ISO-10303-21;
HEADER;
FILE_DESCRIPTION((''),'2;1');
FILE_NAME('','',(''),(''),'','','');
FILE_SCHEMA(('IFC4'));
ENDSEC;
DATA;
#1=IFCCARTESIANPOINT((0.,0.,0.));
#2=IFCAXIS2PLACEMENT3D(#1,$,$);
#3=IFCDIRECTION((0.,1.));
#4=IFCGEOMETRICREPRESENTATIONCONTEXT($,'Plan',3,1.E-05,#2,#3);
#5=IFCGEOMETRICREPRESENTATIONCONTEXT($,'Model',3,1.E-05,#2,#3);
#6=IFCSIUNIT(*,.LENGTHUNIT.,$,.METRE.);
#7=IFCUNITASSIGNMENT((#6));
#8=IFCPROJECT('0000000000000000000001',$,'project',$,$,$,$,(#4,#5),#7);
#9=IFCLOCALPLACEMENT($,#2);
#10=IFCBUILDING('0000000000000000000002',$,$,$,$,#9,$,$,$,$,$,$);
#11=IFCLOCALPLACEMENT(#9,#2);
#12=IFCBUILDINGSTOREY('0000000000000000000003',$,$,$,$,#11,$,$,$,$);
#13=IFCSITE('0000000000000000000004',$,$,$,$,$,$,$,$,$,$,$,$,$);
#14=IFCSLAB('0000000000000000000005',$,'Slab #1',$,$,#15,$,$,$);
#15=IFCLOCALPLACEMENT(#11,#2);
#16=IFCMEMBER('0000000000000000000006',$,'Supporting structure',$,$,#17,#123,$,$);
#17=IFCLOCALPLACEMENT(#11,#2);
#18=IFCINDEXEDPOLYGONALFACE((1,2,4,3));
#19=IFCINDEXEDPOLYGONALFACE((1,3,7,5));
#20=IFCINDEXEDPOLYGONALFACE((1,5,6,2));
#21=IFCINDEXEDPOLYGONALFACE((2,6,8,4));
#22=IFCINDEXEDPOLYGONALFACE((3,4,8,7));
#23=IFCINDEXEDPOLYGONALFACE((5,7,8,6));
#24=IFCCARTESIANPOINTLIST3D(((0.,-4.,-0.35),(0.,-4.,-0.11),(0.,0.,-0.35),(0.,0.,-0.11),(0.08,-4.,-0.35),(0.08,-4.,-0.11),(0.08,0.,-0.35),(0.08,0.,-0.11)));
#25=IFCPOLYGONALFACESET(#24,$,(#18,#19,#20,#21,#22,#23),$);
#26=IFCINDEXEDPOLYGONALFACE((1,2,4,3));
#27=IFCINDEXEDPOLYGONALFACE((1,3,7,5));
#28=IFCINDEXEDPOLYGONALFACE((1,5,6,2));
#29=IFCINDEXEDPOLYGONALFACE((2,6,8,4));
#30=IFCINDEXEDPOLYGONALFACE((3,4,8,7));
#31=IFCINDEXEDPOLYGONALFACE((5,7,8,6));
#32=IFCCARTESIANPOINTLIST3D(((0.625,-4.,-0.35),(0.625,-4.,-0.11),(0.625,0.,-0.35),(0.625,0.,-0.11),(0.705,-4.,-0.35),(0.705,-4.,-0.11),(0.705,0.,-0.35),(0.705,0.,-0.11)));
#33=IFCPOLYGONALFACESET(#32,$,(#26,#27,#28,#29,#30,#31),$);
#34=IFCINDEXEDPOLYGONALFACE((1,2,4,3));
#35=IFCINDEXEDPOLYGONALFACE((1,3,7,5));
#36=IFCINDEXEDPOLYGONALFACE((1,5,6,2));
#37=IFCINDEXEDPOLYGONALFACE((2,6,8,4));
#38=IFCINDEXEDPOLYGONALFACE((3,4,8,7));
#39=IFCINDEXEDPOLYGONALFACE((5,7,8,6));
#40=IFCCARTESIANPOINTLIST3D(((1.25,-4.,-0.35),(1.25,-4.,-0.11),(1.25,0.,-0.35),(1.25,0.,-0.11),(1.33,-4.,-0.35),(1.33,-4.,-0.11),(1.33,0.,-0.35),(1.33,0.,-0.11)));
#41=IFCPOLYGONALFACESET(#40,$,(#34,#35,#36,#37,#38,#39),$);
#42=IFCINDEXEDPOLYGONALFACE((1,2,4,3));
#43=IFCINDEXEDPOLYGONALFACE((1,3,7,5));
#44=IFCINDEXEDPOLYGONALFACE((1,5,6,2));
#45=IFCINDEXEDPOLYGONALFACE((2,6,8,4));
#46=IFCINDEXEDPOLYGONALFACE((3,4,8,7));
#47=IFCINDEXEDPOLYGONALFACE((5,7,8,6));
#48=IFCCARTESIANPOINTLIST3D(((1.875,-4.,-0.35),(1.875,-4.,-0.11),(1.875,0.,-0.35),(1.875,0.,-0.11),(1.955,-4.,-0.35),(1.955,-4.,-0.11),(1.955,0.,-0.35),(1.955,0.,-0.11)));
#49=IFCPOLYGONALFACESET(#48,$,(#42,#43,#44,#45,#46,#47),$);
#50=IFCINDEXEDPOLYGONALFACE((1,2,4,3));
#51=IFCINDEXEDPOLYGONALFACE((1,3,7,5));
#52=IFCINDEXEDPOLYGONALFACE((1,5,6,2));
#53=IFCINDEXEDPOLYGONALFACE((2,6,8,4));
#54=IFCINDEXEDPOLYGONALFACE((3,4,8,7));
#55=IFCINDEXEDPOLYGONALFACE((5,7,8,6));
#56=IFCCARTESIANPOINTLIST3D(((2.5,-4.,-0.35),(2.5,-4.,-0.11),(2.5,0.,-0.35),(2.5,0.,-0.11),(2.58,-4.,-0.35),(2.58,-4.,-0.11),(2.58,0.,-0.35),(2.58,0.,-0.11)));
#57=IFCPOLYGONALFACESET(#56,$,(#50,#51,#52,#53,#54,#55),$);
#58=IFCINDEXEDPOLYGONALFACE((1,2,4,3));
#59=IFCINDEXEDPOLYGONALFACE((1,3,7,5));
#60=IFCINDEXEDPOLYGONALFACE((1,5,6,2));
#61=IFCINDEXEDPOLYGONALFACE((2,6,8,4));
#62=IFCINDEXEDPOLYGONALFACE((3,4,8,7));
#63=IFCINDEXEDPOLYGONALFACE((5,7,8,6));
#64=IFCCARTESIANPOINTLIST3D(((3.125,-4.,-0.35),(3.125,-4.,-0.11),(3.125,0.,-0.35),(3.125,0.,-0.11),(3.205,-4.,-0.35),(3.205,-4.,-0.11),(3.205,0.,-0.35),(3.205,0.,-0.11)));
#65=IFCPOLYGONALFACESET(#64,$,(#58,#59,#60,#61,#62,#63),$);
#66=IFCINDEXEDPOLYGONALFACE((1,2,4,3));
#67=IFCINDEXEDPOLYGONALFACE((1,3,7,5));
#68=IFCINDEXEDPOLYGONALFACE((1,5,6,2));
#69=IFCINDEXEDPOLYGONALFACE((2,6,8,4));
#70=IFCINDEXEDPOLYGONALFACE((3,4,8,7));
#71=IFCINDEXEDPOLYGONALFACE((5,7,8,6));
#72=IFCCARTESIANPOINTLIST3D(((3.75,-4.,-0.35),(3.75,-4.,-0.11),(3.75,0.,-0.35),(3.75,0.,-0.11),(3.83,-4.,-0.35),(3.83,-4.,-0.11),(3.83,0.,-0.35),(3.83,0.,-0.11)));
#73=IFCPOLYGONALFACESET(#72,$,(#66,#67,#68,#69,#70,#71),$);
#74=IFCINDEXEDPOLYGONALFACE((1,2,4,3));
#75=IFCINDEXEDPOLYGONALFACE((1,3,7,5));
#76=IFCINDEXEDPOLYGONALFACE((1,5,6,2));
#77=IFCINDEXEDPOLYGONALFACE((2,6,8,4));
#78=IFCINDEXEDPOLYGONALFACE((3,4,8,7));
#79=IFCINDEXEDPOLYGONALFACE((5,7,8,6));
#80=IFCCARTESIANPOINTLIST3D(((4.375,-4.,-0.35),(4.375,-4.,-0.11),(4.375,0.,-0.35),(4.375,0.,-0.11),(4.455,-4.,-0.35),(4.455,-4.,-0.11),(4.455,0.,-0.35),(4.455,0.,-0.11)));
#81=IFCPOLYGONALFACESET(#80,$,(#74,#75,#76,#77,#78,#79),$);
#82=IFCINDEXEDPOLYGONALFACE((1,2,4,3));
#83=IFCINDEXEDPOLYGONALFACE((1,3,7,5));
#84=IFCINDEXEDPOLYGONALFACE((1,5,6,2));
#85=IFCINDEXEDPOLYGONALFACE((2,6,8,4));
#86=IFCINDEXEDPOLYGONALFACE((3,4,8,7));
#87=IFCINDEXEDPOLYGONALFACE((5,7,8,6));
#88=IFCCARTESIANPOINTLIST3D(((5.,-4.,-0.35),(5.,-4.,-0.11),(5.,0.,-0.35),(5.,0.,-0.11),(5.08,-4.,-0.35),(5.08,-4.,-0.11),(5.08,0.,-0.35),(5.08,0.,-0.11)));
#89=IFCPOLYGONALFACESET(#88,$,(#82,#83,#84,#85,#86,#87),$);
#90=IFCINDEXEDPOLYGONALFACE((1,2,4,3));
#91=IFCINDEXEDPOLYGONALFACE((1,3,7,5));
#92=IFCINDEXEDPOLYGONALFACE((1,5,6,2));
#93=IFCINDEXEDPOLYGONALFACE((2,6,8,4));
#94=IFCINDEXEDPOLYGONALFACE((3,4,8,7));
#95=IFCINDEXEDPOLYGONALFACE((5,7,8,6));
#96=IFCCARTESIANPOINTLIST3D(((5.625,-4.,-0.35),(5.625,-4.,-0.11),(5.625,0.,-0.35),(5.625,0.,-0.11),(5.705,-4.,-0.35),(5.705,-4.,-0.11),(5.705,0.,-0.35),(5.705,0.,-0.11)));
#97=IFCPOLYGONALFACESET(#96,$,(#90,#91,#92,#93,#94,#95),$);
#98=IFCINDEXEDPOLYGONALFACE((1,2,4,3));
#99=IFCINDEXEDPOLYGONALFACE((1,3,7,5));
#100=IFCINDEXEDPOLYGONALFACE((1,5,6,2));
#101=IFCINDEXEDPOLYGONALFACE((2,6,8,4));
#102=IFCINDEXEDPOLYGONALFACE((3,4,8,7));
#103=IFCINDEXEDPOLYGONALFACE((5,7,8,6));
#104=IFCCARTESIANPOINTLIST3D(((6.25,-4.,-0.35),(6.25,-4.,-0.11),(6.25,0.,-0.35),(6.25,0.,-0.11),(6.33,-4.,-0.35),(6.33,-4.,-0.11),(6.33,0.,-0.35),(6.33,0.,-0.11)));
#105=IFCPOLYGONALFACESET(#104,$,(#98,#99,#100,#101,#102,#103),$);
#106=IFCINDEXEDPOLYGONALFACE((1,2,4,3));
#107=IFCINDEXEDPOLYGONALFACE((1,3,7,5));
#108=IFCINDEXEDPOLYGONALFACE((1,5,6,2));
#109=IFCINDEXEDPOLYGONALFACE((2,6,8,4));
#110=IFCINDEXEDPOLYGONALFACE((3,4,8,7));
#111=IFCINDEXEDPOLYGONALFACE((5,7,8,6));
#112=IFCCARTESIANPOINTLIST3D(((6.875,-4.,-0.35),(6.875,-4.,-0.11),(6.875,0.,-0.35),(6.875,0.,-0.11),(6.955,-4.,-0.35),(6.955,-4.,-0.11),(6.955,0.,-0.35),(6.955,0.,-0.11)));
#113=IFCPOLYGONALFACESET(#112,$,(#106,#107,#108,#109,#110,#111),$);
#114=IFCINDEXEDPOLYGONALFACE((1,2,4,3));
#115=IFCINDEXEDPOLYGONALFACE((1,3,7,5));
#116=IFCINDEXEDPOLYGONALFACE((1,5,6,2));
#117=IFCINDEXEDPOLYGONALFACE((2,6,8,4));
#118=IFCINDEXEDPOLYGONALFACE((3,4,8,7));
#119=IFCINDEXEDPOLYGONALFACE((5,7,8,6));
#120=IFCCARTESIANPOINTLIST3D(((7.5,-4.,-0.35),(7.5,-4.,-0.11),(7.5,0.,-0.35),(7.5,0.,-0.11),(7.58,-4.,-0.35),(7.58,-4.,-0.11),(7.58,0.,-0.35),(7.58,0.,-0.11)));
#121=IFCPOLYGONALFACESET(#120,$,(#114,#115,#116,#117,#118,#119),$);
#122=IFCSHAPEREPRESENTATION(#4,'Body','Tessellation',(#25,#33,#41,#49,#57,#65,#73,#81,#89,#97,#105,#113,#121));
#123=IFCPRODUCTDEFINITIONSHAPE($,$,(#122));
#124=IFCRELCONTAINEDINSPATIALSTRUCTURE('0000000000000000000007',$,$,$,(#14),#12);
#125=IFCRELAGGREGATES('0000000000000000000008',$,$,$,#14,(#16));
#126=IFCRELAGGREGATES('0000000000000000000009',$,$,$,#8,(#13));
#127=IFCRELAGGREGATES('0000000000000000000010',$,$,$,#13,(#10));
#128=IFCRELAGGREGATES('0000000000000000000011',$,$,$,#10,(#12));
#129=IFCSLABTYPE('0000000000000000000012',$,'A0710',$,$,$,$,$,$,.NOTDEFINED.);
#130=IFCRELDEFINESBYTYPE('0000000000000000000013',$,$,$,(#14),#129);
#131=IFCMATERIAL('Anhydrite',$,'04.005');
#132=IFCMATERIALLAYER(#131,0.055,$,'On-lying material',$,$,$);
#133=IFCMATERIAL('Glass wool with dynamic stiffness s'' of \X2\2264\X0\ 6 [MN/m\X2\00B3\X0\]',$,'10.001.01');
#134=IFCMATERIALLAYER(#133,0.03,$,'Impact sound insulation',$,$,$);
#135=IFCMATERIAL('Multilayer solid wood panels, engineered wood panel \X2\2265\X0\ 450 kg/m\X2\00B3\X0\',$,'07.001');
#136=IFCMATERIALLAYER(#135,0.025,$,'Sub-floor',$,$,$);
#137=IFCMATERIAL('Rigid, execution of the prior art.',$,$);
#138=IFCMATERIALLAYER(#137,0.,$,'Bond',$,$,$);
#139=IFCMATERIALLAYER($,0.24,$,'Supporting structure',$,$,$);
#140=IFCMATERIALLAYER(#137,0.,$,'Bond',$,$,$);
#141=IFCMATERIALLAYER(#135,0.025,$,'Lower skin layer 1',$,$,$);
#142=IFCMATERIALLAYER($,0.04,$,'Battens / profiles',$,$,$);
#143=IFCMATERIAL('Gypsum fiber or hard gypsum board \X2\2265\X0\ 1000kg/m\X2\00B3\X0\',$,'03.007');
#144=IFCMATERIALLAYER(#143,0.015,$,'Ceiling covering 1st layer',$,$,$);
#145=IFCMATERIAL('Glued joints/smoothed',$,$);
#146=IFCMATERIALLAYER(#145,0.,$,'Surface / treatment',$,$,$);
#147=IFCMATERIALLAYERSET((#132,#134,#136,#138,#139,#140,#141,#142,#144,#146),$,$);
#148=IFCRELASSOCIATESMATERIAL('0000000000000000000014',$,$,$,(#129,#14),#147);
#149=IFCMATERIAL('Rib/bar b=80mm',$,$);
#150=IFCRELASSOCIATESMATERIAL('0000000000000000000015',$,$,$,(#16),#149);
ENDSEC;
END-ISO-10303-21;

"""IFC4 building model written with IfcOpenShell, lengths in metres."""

from ifc_helpers import new_model, si_unit, direction, frame, frame_2d, origin, place, context, project, spatial, rectangle, extrude, material, layer, layer_set, type_object, element, aggregate, save


model = new_model("IFC4")

# Units and contexts
plan_context = context("Plan", 3, precision=1e-05, world=origin(), true_north=direction((0.0, 1.0)))
model_context = context("Model", 3, precision=1e-05, world=origin(), true_north=direction((0.0, 1.0)))
ifc_project = project(units=[si_unit("LENGTHUNIT", "METRE")], contexts=[plan_context, model_context])

# Site, building, storey
site = spatial("IfcSite", under=ifc_project)
building_placement = place(None, origin())
building = spatial("IfcBuilding", under=site, at=building_placement)
storey_placement = place(building_placement, origin())
storey = spatial("IfcBuildingStorey", under=building, at=storey_placement)

# Slab, member
ifc_material_1 = material(Name="Anhydrite", Category="04.005")
ifc_layer_1 = layer(ifc_material_1, 0.055, Name="On-lying material")
ifc_material_2 = material(Name="Glass wool with dynamic stiffness s' of ≤ 6 [MN/m³]", Category="10.001.01")
ifc_layer_2 = layer(ifc_material_2, 0.03, Name="Impact sound insulation")
ifc_material_3 = material(Name="Multilayer solid wood panels, engineered wood panel ≥ 450 kg/m³", Category="07.001")
ifc_layer_3 = layer(ifc_material_3, 0.025, Name="Sub-floor")
ifc_material_4 = material(Name="Rigid, execution of the prior art.")
ifc_layer_4 = layer(ifc_material_4, 0.0, Name="Bond")
ifc_layer_5 = layer(None, 0.24, Name="Supporting structure")
ifc_layer_6 = layer(ifc_material_4, 0.0, Name="Bond")
ifc_layer_7 = layer(ifc_material_3, 0.025, Name="Lower skin layer 1")
ifc_layer_8 = layer(None, 0.04, Name="Battens / profiles")
ifc_material_5 = material(Name="Gypsum fiber or hard gypsum board ≥ 1000kg/m³", Category="03.007")
ifc_layer_9 = layer(ifc_material_5, 0.015, Name="Ceiling covering 1st layer")
ifc_material_6 = material(Name="Glued joints/smoothed")
ifc_layer_10 = layer(ifc_material_6, 0.0, Name="Surface / treatment")
ifc_layer_set = layer_set([ifc_layer_1, ifc_layer_2, ifc_layer_3, ifc_layer_4, ifc_layer_5, ifc_layer_6, ifc_layer_7, ifc_layer_8, ifc_layer_9, ifc_layer_10])
slab_type = type_object("IfcSlabType", Name="A0710", PredefinedType="NOTDEFINED", material=ifc_layer_set)
slab_placement = place(None, frame((0.0, 0.0, 0.0), z_axis=(0.0, 0.0, -1.0), x_axis=(1.0, 0.0, 0.0)))
slab = element("IfcSlab", 1, at=slab_placement, inside=storey, type_object=slab_type, material=ifc_layer_set, Name="Slab #1")
ifc_material_7 = material(Name="Rib/bar b=80mm")
member_1_placement = place(slab_placement, origin())
member_1 = element("IfcMember", 2, at=member_1_placement, material=ifc_material_7, Name="Supporting structure", context=plan_context, shape_type="SweptSolid", body=[
    extrude(rectangle(XDim=0.08, YDim=0.24, at=frame_2d((0.04, 0.12), x_axis=(1.0, 0.0))), frame((0.0, 4.0, 0.11), z_axis=(0.0, -1.0, 0.0), x_axis=(1.0, 0.0, 0.0)), (0.0, 0.0, 1.0), 4.0),
    extrude(rectangle(XDim=0.08, YDim=0.24, at=frame_2d((0.04, 0.12), x_axis=(1.0, 0.0))), frame((0.625, 4.0, 0.11), z_axis=(0.0, -1.0, 0.0), x_axis=(1.0, 0.0, 0.0)), (0.0, 0.0, 1.0), 4.0),
    extrude(rectangle(XDim=0.08, YDim=0.24, at=frame_2d((0.04, 0.12), x_axis=(1.0, 0.0))), frame((1.25, 4.0, 0.11), z_axis=(0.0, -1.0, 0.0), x_axis=(1.0, 0.0, 0.0)), (0.0, 0.0, 1.0), 4.0),
    extrude(rectangle(XDim=0.08, YDim=0.24, at=frame_2d((0.04, 0.12), x_axis=(1.0, 0.0))), frame((1.875, 4.0, 0.11), z_axis=(0.0, -1.0, 0.0), x_axis=(1.0, 0.0, 0.0)), (0.0, 0.0, 1.0), 4.0),
    extrude(rectangle(XDim=0.08, YDim=0.24, at=frame_2d((0.04, 0.12), x_axis=(1.0, 0.0))), frame((2.5, 4.0, 0.11), z_axis=(0.0, -1.0, 0.0), x_axis=(1.0, 0.0, 0.0)), (0.0, 0.0, 1.0), 4.0),
    extrude(rectangle(XDim=0.08, YDim=0.24, at=frame_2d((0.04, 0.12), x_axis=(1.0, 0.0))), frame((3.125, 4.0, 0.11), z_axis=(0.0, -1.0, 0.0), x_axis=(1.0, 0.0, 0.0)), (0.0, 0.0, 1.0), 4.0),
    extrude(rectangle(XDim=0.08, YDim=0.24, at=frame_2d((0.04, 0.12), x_axis=(1.0, 0.0))), frame((3.75, 4.0, 0.11), z_axis=(0.0, -1.0, 0.0), x_axis=(1.0, 0.0, 0.0)), (0.0, 0.0, 1.0), 4.0),
    extrude(rectangle(XDim=0.08, YDim=0.24, at=frame_2d((0.04, 0.12), x_axis=(1.0, 0.0))), frame((4.375, 4.0, 0.11), z_axis=(0.0, -1.0, 0.0), x_axis=(1.0, 0.0, 0.0)), (0.0, 0.0, 1.0), 4.0),
    extrude(rectangle(XDim=0.08, YDim=0.24, at=frame_2d((0.04, 0.12), x_axis=(1.0, 0.0))), frame((5.0, 4.0, 0.11), z_axis=(0.0, -1.0, 0.0), x_axis=(1.0, 0.0, 0.0)), (0.0, 0.0, 1.0), 4.0),
    extrude(rectangle(XDim=0.08, YDim=0.24, at=frame_2d((0.04, 0.12), x_axis=(1.0, 0.0))), frame((5.625, 4.0, 0.11), z_axis=(0.0, -1.0, 0.0), x_axis=(1.0, 0.0, 0.0)), (0.0, 0.0, 1.0), 4.0),
    extrude(rectangle(XDim=0.08, YDim=0.24, at=frame_2d((0.04, 0.12), x_axis=(1.0, 0.0))), frame((6.25, 4.0, 0.11), z_axis=(0.0, -1.0, 0.0), x_axis=(1.0, 0.0, 0.0)), (0.0, 0.0, 1.0), 4.0),
    extrude(rectangle(XDim=0.08, YDim=0.24, at=frame_2d((0.04, 0.12), x_axis=(1.0, 0.0))), frame((6.875, 4.0, 0.11), z_axis=(0.0, -1.0, 0.0), x_axis=(1.0, 0.0, 0.0)), (0.0, 0.0, 1.0), 4.0),
    extrude(rectangle(XDim=0.08, YDim=0.24, at=frame_2d((0.04, 0.12), x_axis=(1.0, 0.0))), frame((7.5, 4.0, 0.11), z_axis=(0.0, -1.0, 0.0), x_axis=(1.0, 0.0, 0.0)), (0.0, 0.0, 1.0), 4.0),
])
aggregate(slab, [member_1])

save(model, "model.ifc")
